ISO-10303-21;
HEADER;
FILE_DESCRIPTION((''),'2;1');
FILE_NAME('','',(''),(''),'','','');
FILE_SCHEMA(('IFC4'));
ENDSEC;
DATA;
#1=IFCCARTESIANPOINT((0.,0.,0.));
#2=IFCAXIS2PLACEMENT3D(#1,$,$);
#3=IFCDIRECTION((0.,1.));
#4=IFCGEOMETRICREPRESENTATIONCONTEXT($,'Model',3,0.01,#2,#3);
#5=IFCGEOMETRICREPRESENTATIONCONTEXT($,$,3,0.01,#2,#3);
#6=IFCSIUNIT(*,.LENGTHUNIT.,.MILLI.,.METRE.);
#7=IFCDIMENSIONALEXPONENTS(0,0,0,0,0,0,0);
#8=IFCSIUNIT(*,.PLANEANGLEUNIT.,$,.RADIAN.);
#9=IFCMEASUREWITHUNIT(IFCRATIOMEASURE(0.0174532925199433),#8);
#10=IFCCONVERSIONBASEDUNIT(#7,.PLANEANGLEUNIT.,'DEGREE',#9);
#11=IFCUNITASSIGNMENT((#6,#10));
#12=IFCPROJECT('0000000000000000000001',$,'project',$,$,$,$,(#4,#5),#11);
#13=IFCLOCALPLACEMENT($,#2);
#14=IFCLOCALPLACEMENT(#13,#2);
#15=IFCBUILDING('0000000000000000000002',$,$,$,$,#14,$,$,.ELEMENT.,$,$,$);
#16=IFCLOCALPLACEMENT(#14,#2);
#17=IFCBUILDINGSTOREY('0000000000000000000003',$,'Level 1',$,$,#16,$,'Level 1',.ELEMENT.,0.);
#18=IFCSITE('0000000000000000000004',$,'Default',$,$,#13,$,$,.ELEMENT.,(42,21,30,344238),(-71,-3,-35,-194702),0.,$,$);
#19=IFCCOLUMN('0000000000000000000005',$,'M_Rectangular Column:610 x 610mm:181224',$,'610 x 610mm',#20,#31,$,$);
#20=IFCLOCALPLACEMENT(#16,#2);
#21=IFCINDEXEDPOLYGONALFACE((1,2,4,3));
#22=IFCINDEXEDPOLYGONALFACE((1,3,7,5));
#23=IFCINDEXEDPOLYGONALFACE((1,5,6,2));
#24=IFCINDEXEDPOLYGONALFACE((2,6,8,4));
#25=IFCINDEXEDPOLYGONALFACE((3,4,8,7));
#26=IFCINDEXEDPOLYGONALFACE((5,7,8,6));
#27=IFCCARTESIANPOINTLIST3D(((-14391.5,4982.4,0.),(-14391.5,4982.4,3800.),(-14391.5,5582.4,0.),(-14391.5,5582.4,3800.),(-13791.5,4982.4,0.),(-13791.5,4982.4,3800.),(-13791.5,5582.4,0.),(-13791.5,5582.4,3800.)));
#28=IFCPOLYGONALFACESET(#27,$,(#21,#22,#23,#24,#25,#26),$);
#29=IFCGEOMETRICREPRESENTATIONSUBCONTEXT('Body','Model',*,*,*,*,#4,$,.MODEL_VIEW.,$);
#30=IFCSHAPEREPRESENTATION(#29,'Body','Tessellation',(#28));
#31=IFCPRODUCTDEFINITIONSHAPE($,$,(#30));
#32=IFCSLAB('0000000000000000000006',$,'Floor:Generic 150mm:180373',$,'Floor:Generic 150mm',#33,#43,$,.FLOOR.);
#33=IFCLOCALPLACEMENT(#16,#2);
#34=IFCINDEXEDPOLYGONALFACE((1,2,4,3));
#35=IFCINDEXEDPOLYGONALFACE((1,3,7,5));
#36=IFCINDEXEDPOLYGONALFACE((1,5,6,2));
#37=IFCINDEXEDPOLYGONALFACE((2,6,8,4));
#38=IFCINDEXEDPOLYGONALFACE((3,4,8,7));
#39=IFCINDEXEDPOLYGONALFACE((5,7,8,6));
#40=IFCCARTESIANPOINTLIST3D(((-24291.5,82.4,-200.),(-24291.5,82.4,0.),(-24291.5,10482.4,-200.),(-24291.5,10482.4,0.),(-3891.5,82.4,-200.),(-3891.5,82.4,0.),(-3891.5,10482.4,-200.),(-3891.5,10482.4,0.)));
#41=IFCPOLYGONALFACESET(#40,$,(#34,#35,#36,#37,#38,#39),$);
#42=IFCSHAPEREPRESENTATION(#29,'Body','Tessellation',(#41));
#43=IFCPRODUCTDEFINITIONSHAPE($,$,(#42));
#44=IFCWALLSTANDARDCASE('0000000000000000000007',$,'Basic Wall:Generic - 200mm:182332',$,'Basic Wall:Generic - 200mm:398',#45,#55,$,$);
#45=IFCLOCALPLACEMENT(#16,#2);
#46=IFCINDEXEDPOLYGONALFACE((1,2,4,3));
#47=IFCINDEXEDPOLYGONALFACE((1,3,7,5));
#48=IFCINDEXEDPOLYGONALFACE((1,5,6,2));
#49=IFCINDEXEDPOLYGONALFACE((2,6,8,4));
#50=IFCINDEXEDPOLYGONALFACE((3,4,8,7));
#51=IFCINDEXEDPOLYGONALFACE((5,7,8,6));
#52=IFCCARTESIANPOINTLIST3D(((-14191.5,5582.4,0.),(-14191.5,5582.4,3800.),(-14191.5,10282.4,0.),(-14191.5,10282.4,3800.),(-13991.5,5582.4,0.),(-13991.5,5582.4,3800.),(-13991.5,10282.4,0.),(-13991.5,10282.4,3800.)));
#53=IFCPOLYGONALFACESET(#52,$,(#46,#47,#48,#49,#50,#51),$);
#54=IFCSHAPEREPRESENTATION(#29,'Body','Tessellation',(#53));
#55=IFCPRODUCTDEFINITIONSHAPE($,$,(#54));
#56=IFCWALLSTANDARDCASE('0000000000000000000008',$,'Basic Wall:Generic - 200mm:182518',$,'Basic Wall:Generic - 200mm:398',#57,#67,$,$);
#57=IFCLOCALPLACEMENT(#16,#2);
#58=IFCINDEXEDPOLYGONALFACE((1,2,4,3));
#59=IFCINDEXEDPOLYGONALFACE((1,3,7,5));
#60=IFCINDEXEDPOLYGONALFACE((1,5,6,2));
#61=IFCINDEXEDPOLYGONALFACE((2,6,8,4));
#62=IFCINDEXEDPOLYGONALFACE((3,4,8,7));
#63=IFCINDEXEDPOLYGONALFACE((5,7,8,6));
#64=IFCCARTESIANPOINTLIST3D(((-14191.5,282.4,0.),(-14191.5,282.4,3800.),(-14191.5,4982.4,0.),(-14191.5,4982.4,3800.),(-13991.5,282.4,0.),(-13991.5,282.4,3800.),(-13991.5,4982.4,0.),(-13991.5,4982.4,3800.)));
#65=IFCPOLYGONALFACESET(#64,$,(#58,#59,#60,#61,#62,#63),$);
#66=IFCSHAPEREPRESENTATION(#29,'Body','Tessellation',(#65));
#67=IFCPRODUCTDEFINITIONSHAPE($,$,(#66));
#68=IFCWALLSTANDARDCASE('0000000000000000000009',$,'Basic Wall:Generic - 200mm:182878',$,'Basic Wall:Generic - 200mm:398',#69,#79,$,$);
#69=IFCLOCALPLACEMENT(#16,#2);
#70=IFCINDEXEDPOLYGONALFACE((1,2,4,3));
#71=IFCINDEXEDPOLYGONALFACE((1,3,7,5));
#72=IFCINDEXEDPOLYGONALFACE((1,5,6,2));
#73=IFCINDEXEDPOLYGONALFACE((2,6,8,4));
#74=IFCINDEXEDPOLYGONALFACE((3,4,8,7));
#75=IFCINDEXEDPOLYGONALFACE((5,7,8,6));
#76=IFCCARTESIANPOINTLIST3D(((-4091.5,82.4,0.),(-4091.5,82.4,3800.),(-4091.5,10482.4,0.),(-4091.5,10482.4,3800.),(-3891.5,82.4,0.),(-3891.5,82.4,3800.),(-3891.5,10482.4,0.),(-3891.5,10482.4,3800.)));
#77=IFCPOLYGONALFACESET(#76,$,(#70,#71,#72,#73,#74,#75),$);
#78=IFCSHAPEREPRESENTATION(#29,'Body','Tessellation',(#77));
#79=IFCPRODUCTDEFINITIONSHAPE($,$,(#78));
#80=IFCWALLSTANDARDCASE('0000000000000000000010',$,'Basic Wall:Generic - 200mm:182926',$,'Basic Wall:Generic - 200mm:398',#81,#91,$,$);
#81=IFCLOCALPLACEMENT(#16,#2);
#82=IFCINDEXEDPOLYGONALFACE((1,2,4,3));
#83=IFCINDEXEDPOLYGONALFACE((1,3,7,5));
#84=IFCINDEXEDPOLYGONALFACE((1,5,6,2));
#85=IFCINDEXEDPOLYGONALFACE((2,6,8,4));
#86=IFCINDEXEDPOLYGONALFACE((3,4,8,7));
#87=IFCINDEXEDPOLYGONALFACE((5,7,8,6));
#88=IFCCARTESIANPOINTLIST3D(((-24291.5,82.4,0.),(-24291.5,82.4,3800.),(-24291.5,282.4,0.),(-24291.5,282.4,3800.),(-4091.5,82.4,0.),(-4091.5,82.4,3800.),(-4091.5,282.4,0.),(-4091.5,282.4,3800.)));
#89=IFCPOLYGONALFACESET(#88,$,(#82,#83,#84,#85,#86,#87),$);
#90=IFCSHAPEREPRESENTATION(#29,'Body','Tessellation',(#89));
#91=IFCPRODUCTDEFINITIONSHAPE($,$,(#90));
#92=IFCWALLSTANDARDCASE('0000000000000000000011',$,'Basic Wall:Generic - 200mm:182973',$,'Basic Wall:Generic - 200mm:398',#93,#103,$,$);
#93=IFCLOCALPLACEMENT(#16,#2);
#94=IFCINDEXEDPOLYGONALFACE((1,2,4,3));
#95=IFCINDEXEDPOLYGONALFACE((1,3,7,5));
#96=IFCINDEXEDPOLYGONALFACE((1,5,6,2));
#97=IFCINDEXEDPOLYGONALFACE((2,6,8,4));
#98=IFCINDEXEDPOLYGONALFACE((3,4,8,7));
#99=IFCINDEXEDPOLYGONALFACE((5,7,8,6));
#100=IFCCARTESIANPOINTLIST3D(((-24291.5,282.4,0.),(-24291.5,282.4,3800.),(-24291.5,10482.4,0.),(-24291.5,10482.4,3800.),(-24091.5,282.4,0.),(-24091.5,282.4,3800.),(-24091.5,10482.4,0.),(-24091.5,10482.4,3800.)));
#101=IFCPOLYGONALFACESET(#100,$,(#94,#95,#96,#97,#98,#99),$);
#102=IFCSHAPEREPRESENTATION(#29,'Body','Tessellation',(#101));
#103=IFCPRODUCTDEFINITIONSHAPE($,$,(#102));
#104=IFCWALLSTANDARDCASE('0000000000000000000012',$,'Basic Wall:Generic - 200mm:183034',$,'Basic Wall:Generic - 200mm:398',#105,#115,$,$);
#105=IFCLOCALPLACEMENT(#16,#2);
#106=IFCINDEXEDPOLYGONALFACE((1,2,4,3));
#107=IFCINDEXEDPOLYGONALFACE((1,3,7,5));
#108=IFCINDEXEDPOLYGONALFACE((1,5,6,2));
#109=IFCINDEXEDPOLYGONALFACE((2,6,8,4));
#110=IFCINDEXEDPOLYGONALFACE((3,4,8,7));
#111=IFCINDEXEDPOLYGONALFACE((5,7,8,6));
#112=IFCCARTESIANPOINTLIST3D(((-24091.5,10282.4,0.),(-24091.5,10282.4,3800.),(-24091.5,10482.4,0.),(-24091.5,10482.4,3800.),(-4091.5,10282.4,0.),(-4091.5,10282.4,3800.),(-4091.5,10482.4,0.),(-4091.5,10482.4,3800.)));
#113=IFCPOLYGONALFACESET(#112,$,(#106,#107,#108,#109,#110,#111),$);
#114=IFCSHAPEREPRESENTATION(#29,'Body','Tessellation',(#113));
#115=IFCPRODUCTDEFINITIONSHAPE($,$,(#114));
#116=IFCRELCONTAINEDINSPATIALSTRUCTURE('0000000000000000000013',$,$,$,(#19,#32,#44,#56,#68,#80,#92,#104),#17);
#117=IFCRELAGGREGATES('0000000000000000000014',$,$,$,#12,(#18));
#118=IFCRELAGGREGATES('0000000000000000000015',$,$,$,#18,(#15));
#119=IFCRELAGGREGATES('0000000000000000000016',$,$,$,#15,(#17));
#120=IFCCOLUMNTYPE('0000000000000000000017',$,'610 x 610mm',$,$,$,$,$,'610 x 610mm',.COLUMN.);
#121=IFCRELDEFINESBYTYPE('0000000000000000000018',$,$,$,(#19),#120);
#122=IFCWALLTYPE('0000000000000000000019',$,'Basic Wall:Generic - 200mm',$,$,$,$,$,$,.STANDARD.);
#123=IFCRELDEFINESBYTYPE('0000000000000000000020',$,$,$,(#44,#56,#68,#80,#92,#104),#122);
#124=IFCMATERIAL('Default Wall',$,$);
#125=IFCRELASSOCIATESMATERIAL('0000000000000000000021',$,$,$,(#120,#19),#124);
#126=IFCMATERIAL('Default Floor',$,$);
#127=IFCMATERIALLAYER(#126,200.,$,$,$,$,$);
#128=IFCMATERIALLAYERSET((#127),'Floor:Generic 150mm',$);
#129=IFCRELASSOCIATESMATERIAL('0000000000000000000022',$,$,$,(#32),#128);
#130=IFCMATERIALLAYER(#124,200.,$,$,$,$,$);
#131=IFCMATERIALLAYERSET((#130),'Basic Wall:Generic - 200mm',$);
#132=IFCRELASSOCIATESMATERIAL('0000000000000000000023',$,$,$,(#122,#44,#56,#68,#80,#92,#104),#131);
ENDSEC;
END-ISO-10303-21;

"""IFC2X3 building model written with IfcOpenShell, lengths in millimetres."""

from ifc_helpers import new_model, entity, si_unit, converted_unit, direction, frame, frame_2d, origin, origin_2d_with_axis, place, context, subcontext, project, spatial, rectangle, extrude, source, transform, mapped, material, layer, layer_set, layer_usage, type_object, type_shapes, element, save


model = new_model("IFC2X3")

# Units and contexts
model_context = context("Model", 3, precision=0.01, world=origin(), true_north=direction((0.0, 1.0)))
context_of_model = context(None, 3, precision=0.01, world=origin(), true_north=direction((0.0, 1.0)))
body_context = subcontext(model_context, "Body", "Model", "MODEL_VIEW")
ifc_project = project(units=[si_unit("LENGTHUNIT", "METRE", prefix="MILLI"), converted_unit("PLANEANGLEUNIT", "DEGREE", entity("IfcRatioMeasure", 0.0174532925199433), si_unit("PLANEANGLEUNIT", "RADIAN"), dimensions=[0, 0, 0, 0, 0, 0, 0])], contexts=[model_context, context_of_model])

# Site, building, storey
site_placement = place(None, origin())
site = spatial("IfcSite", under=ifc_project, at=site_placement, Name="Default", CompositionType="ELEMENT", RefLatitude=(42, 21, 30, 344238), RefLongitude=(-71, -3, -35, -194702), RefElevation=0.0)
building_placement = place(site_placement, origin())
building = spatial("IfcBuilding", under=site, at=building_placement, CompositionType="ELEMENT")
storey_placement = place(building_placement, origin())
storey = spatial("IfcBuildingStorey", under=building, at=storey_placement, Name="Level 1", LongName="Level 1", CompositionType="ELEMENT", Elevation=0.0)

# Column
ifc_material_1 = material(Name="Default Wall")
column_type = type_object("IfcColumnType", Name="610 x 610mm", ElementType="610 x 610mm", PredefinedType="COLUMN", material=ifc_material_1)
shared_shape = source(origin(), body_context, "Body", "SweptSolid", [
    extrude(rectangle(XDim=600.0, YDim=600.0, at=frame_2d((0.0, 0.0), x_axis=(1.0, 0.0))), frame((-14091.5, 5282.4, 0.0), z_axis=(0.0, 0.0, 1.0), x_axis=(-1.0, 0.0, 0.0)), (0.0, 0.0, 1.0), 3800.0),
])
type_shapes(column_type, [shared_shape])
column_placement = place(storey_placement, origin())
element("IfcColumn", 1, at=column_placement, inside=storey, type_object=column_type, material=ifc_material_1, Name="M_Rectangular Column:610 x 610mm:181224", ObjectType="610 x 610mm", context=body_context, shape_type="MappedRepresentation", body=[
    mapped(shared_shape, transform((0.0, 0.0, 0.0), scale=1.0)),
])

# Slab
ifc_material_2 = material(Name="Default Floor")
ifc_layer_1 = layer(ifc_material_2, 200.0)
ifc_layer_set_1 = layer_set([ifc_layer_1], Name="Floor:Generic 150mm")
ifc_layer_usage_1 = layer_usage(ifc_layer_set_1, "AXIS3", "POSITIVE", 0.0)
slab_placement = place(storey_placement, origin())
element("IfcSlab", 2, at=slab_placement, inside=storey, material=ifc_layer_usage_1, Name="Floor:Generic 150mm:180373", ObjectType="Floor:Generic 150mm", PredefinedType="FLOOR", context=body_context, shape_type="SweptSolid", body=[
    extrude(rectangle(XDim=10400.0, YDim=20400.0, at=origin_2d_with_axis()), frame((-14091.5, 5282.4, 0.0), z_axis=(0.0, 0.0, -1.0), x_axis=(0.0, 1.0, 0.0)), (0.0, 0.0, 1.0), 200.0),
])

# Walls
ifc_layer_2 = layer(ifc_material_1, 200.0)
ifc_layer_set_2 = layer_set([ifc_layer_2], Name="Basic Wall:Generic - 200mm")
ifc_layer_usage_2 = layer_usage(ifc_layer_set_2, "AXIS2", "NEGATIVE", 100.0)
wall_type = type_object("IfcWallType", Name="Basic Wall:Generic - 200mm", PredefinedType="STANDARD", material=ifc_layer_set_2)
wall_1_placement = place(storey_placement, frame((-14091.5, 10282.4, 0.0), z_axis=(0.0, 0.0, 1.0), x_axis=(0.0, -1.0, 0.0)))
element("IfcWallStandardCase", 3, at=wall_1_placement, inside=storey, type_object=wall_type, material=ifc_layer_usage_2, Name="Basic Wall:Generic - 200mm:182332", ObjectType="Basic Wall:Generic - 200mm:398", context=body_context, shape_type="SweptSolid", body=[
    extrude(rectangle(XDim=4700.0, YDim=200.0, at=frame_2d((2350.0, 0.0), x_axis=(-1.0, 0.0))), origin(), (0.0, 0.0, 1.0), 3800.0),
])
ifc_layer_usage_3 = layer_usage(ifc_layer_set_2, "AXIS2", "NEGATIVE", 100.0)
wall_2_placement = place(storey_placement, frame((-14091.5, 282.4, 0.0), z_axis=(0.0, 0.0, 1.0), x_axis=(0.0, 1.0, 0.0)))
element("IfcWallStandardCase", 4, at=wall_2_placement, inside=storey, type_object=wall_type, material=ifc_layer_usage_3, Name="Basic Wall:Generic - 200mm:182518", ObjectType="Basic Wall:Generic - 200mm:398", context=body_context, shape_type="SweptSolid", body=[
    extrude(rectangle(XDim=4700.0, YDim=200.0, at=frame_2d((2350.0, 0.0), x_axis=(-1.0, 0.0))), origin(), (0.0, 0.0, 1.0), 3800.0),
])
ifc_layer_usage_4 = layer_usage(ifc_layer_set_2, "AXIS2", "NEGATIVE", 100.0)
wall_3_placement = place(storey_placement, frame((-3991.5, 10482.4, 0.0), z_axis=(0.0, 0.0, 1.0), x_axis=(0.0, -1.0, 0.0)))
element("IfcWallStandardCase", 5, at=wall_3_placement, inside=storey, type_object=wall_type, material=ifc_layer_usage_4, Name="Basic Wall:Generic - 200mm:182878", ObjectType="Basic Wall:Generic - 200mm:398", context=body_context, shape_type="SweptSolid", body=[
    extrude(rectangle(XDim=10400.0, YDim=200.0, at=frame_2d((5200.0, 0.0), x_axis=(-1.0, 0.0))), origin(), (0.0, 0.0, 1.0), 3800.0),
])
ifc_layer_usage_5 = layer_usage(ifc_layer_set_2, "AXIS2", "NEGATIVE", 100.0)
wall_4_placement = place(storey_placement, frame((-4091.5, 182.4, 0.0), z_axis=(0.0, 0.0, 1.0), x_axis=(-1.0, 0.0, 0.0)))
element("IfcWallStandardCase", 6, at=wall_4_placement, inside=storey, type_object=wall_type, material=ifc_layer_usage_5, Name="Basic Wall:Generic - 200mm:182926", ObjectType="Basic Wall:Generic - 200mm:398", context=body_context, shape_type="SweptSolid", body=[
    extrude(rectangle(XDim=20200.0, YDim=200.0, at=frame_2d((10100.0, 0.0), x_axis=(-1.0, 0.0))), origin(), (0.0, 0.0, 1.0), 3800.0),
])
ifc_layer_usage_6 = layer_usage(ifc_layer_set_2, "AXIS2", "NEGATIVE", 100.0)
wall_5_placement = place(storey_placement, frame((-24191.5, 282.4, 0.0), z_axis=(0.0, 0.0, 1.0), x_axis=(0.0, 1.0, 0.0)))
element("IfcWallStandardCase", 7, at=wall_5_placement, inside=storey, type_object=wall_type, material=ifc_layer_usage_6, Name="Basic Wall:Generic - 200mm:182973", ObjectType="Basic Wall:Generic - 200mm:398", context=body_context, shape_type="SweptSolid", body=[
    extrude(rectangle(XDim=10200.0, YDim=200.0, at=frame_2d((5100.0, 0.0), x_axis=(-1.0, 0.0))), origin(), (0.0, 0.0, 1.0), 3800.0),
])
ifc_layer_usage_7 = layer_usage(ifc_layer_set_2, "AXIS2", "NEGATIVE", 100.0)
wall_6_placement = place(storey_placement, frame((-24091.5, 10382.4, 0.0)))
element("IfcWallStandardCase", 8, at=wall_6_placement, inside=storey, type_object=wall_type, material=ifc_layer_usage_7, Name="Basic Wall:Generic - 200mm:183034", ObjectType="Basic Wall:Generic - 200mm:398", context=body_context, shape_type="SweptSolid", body=[
    extrude(rectangle(XDim=20000.0, YDim=200.0, at=frame_2d((10000.0, 0.0), x_axis=(-1.0, 0.0))), origin(), (0.0, 0.0, 1.0), 3800.0),
])

save(model, "model.ifc")
